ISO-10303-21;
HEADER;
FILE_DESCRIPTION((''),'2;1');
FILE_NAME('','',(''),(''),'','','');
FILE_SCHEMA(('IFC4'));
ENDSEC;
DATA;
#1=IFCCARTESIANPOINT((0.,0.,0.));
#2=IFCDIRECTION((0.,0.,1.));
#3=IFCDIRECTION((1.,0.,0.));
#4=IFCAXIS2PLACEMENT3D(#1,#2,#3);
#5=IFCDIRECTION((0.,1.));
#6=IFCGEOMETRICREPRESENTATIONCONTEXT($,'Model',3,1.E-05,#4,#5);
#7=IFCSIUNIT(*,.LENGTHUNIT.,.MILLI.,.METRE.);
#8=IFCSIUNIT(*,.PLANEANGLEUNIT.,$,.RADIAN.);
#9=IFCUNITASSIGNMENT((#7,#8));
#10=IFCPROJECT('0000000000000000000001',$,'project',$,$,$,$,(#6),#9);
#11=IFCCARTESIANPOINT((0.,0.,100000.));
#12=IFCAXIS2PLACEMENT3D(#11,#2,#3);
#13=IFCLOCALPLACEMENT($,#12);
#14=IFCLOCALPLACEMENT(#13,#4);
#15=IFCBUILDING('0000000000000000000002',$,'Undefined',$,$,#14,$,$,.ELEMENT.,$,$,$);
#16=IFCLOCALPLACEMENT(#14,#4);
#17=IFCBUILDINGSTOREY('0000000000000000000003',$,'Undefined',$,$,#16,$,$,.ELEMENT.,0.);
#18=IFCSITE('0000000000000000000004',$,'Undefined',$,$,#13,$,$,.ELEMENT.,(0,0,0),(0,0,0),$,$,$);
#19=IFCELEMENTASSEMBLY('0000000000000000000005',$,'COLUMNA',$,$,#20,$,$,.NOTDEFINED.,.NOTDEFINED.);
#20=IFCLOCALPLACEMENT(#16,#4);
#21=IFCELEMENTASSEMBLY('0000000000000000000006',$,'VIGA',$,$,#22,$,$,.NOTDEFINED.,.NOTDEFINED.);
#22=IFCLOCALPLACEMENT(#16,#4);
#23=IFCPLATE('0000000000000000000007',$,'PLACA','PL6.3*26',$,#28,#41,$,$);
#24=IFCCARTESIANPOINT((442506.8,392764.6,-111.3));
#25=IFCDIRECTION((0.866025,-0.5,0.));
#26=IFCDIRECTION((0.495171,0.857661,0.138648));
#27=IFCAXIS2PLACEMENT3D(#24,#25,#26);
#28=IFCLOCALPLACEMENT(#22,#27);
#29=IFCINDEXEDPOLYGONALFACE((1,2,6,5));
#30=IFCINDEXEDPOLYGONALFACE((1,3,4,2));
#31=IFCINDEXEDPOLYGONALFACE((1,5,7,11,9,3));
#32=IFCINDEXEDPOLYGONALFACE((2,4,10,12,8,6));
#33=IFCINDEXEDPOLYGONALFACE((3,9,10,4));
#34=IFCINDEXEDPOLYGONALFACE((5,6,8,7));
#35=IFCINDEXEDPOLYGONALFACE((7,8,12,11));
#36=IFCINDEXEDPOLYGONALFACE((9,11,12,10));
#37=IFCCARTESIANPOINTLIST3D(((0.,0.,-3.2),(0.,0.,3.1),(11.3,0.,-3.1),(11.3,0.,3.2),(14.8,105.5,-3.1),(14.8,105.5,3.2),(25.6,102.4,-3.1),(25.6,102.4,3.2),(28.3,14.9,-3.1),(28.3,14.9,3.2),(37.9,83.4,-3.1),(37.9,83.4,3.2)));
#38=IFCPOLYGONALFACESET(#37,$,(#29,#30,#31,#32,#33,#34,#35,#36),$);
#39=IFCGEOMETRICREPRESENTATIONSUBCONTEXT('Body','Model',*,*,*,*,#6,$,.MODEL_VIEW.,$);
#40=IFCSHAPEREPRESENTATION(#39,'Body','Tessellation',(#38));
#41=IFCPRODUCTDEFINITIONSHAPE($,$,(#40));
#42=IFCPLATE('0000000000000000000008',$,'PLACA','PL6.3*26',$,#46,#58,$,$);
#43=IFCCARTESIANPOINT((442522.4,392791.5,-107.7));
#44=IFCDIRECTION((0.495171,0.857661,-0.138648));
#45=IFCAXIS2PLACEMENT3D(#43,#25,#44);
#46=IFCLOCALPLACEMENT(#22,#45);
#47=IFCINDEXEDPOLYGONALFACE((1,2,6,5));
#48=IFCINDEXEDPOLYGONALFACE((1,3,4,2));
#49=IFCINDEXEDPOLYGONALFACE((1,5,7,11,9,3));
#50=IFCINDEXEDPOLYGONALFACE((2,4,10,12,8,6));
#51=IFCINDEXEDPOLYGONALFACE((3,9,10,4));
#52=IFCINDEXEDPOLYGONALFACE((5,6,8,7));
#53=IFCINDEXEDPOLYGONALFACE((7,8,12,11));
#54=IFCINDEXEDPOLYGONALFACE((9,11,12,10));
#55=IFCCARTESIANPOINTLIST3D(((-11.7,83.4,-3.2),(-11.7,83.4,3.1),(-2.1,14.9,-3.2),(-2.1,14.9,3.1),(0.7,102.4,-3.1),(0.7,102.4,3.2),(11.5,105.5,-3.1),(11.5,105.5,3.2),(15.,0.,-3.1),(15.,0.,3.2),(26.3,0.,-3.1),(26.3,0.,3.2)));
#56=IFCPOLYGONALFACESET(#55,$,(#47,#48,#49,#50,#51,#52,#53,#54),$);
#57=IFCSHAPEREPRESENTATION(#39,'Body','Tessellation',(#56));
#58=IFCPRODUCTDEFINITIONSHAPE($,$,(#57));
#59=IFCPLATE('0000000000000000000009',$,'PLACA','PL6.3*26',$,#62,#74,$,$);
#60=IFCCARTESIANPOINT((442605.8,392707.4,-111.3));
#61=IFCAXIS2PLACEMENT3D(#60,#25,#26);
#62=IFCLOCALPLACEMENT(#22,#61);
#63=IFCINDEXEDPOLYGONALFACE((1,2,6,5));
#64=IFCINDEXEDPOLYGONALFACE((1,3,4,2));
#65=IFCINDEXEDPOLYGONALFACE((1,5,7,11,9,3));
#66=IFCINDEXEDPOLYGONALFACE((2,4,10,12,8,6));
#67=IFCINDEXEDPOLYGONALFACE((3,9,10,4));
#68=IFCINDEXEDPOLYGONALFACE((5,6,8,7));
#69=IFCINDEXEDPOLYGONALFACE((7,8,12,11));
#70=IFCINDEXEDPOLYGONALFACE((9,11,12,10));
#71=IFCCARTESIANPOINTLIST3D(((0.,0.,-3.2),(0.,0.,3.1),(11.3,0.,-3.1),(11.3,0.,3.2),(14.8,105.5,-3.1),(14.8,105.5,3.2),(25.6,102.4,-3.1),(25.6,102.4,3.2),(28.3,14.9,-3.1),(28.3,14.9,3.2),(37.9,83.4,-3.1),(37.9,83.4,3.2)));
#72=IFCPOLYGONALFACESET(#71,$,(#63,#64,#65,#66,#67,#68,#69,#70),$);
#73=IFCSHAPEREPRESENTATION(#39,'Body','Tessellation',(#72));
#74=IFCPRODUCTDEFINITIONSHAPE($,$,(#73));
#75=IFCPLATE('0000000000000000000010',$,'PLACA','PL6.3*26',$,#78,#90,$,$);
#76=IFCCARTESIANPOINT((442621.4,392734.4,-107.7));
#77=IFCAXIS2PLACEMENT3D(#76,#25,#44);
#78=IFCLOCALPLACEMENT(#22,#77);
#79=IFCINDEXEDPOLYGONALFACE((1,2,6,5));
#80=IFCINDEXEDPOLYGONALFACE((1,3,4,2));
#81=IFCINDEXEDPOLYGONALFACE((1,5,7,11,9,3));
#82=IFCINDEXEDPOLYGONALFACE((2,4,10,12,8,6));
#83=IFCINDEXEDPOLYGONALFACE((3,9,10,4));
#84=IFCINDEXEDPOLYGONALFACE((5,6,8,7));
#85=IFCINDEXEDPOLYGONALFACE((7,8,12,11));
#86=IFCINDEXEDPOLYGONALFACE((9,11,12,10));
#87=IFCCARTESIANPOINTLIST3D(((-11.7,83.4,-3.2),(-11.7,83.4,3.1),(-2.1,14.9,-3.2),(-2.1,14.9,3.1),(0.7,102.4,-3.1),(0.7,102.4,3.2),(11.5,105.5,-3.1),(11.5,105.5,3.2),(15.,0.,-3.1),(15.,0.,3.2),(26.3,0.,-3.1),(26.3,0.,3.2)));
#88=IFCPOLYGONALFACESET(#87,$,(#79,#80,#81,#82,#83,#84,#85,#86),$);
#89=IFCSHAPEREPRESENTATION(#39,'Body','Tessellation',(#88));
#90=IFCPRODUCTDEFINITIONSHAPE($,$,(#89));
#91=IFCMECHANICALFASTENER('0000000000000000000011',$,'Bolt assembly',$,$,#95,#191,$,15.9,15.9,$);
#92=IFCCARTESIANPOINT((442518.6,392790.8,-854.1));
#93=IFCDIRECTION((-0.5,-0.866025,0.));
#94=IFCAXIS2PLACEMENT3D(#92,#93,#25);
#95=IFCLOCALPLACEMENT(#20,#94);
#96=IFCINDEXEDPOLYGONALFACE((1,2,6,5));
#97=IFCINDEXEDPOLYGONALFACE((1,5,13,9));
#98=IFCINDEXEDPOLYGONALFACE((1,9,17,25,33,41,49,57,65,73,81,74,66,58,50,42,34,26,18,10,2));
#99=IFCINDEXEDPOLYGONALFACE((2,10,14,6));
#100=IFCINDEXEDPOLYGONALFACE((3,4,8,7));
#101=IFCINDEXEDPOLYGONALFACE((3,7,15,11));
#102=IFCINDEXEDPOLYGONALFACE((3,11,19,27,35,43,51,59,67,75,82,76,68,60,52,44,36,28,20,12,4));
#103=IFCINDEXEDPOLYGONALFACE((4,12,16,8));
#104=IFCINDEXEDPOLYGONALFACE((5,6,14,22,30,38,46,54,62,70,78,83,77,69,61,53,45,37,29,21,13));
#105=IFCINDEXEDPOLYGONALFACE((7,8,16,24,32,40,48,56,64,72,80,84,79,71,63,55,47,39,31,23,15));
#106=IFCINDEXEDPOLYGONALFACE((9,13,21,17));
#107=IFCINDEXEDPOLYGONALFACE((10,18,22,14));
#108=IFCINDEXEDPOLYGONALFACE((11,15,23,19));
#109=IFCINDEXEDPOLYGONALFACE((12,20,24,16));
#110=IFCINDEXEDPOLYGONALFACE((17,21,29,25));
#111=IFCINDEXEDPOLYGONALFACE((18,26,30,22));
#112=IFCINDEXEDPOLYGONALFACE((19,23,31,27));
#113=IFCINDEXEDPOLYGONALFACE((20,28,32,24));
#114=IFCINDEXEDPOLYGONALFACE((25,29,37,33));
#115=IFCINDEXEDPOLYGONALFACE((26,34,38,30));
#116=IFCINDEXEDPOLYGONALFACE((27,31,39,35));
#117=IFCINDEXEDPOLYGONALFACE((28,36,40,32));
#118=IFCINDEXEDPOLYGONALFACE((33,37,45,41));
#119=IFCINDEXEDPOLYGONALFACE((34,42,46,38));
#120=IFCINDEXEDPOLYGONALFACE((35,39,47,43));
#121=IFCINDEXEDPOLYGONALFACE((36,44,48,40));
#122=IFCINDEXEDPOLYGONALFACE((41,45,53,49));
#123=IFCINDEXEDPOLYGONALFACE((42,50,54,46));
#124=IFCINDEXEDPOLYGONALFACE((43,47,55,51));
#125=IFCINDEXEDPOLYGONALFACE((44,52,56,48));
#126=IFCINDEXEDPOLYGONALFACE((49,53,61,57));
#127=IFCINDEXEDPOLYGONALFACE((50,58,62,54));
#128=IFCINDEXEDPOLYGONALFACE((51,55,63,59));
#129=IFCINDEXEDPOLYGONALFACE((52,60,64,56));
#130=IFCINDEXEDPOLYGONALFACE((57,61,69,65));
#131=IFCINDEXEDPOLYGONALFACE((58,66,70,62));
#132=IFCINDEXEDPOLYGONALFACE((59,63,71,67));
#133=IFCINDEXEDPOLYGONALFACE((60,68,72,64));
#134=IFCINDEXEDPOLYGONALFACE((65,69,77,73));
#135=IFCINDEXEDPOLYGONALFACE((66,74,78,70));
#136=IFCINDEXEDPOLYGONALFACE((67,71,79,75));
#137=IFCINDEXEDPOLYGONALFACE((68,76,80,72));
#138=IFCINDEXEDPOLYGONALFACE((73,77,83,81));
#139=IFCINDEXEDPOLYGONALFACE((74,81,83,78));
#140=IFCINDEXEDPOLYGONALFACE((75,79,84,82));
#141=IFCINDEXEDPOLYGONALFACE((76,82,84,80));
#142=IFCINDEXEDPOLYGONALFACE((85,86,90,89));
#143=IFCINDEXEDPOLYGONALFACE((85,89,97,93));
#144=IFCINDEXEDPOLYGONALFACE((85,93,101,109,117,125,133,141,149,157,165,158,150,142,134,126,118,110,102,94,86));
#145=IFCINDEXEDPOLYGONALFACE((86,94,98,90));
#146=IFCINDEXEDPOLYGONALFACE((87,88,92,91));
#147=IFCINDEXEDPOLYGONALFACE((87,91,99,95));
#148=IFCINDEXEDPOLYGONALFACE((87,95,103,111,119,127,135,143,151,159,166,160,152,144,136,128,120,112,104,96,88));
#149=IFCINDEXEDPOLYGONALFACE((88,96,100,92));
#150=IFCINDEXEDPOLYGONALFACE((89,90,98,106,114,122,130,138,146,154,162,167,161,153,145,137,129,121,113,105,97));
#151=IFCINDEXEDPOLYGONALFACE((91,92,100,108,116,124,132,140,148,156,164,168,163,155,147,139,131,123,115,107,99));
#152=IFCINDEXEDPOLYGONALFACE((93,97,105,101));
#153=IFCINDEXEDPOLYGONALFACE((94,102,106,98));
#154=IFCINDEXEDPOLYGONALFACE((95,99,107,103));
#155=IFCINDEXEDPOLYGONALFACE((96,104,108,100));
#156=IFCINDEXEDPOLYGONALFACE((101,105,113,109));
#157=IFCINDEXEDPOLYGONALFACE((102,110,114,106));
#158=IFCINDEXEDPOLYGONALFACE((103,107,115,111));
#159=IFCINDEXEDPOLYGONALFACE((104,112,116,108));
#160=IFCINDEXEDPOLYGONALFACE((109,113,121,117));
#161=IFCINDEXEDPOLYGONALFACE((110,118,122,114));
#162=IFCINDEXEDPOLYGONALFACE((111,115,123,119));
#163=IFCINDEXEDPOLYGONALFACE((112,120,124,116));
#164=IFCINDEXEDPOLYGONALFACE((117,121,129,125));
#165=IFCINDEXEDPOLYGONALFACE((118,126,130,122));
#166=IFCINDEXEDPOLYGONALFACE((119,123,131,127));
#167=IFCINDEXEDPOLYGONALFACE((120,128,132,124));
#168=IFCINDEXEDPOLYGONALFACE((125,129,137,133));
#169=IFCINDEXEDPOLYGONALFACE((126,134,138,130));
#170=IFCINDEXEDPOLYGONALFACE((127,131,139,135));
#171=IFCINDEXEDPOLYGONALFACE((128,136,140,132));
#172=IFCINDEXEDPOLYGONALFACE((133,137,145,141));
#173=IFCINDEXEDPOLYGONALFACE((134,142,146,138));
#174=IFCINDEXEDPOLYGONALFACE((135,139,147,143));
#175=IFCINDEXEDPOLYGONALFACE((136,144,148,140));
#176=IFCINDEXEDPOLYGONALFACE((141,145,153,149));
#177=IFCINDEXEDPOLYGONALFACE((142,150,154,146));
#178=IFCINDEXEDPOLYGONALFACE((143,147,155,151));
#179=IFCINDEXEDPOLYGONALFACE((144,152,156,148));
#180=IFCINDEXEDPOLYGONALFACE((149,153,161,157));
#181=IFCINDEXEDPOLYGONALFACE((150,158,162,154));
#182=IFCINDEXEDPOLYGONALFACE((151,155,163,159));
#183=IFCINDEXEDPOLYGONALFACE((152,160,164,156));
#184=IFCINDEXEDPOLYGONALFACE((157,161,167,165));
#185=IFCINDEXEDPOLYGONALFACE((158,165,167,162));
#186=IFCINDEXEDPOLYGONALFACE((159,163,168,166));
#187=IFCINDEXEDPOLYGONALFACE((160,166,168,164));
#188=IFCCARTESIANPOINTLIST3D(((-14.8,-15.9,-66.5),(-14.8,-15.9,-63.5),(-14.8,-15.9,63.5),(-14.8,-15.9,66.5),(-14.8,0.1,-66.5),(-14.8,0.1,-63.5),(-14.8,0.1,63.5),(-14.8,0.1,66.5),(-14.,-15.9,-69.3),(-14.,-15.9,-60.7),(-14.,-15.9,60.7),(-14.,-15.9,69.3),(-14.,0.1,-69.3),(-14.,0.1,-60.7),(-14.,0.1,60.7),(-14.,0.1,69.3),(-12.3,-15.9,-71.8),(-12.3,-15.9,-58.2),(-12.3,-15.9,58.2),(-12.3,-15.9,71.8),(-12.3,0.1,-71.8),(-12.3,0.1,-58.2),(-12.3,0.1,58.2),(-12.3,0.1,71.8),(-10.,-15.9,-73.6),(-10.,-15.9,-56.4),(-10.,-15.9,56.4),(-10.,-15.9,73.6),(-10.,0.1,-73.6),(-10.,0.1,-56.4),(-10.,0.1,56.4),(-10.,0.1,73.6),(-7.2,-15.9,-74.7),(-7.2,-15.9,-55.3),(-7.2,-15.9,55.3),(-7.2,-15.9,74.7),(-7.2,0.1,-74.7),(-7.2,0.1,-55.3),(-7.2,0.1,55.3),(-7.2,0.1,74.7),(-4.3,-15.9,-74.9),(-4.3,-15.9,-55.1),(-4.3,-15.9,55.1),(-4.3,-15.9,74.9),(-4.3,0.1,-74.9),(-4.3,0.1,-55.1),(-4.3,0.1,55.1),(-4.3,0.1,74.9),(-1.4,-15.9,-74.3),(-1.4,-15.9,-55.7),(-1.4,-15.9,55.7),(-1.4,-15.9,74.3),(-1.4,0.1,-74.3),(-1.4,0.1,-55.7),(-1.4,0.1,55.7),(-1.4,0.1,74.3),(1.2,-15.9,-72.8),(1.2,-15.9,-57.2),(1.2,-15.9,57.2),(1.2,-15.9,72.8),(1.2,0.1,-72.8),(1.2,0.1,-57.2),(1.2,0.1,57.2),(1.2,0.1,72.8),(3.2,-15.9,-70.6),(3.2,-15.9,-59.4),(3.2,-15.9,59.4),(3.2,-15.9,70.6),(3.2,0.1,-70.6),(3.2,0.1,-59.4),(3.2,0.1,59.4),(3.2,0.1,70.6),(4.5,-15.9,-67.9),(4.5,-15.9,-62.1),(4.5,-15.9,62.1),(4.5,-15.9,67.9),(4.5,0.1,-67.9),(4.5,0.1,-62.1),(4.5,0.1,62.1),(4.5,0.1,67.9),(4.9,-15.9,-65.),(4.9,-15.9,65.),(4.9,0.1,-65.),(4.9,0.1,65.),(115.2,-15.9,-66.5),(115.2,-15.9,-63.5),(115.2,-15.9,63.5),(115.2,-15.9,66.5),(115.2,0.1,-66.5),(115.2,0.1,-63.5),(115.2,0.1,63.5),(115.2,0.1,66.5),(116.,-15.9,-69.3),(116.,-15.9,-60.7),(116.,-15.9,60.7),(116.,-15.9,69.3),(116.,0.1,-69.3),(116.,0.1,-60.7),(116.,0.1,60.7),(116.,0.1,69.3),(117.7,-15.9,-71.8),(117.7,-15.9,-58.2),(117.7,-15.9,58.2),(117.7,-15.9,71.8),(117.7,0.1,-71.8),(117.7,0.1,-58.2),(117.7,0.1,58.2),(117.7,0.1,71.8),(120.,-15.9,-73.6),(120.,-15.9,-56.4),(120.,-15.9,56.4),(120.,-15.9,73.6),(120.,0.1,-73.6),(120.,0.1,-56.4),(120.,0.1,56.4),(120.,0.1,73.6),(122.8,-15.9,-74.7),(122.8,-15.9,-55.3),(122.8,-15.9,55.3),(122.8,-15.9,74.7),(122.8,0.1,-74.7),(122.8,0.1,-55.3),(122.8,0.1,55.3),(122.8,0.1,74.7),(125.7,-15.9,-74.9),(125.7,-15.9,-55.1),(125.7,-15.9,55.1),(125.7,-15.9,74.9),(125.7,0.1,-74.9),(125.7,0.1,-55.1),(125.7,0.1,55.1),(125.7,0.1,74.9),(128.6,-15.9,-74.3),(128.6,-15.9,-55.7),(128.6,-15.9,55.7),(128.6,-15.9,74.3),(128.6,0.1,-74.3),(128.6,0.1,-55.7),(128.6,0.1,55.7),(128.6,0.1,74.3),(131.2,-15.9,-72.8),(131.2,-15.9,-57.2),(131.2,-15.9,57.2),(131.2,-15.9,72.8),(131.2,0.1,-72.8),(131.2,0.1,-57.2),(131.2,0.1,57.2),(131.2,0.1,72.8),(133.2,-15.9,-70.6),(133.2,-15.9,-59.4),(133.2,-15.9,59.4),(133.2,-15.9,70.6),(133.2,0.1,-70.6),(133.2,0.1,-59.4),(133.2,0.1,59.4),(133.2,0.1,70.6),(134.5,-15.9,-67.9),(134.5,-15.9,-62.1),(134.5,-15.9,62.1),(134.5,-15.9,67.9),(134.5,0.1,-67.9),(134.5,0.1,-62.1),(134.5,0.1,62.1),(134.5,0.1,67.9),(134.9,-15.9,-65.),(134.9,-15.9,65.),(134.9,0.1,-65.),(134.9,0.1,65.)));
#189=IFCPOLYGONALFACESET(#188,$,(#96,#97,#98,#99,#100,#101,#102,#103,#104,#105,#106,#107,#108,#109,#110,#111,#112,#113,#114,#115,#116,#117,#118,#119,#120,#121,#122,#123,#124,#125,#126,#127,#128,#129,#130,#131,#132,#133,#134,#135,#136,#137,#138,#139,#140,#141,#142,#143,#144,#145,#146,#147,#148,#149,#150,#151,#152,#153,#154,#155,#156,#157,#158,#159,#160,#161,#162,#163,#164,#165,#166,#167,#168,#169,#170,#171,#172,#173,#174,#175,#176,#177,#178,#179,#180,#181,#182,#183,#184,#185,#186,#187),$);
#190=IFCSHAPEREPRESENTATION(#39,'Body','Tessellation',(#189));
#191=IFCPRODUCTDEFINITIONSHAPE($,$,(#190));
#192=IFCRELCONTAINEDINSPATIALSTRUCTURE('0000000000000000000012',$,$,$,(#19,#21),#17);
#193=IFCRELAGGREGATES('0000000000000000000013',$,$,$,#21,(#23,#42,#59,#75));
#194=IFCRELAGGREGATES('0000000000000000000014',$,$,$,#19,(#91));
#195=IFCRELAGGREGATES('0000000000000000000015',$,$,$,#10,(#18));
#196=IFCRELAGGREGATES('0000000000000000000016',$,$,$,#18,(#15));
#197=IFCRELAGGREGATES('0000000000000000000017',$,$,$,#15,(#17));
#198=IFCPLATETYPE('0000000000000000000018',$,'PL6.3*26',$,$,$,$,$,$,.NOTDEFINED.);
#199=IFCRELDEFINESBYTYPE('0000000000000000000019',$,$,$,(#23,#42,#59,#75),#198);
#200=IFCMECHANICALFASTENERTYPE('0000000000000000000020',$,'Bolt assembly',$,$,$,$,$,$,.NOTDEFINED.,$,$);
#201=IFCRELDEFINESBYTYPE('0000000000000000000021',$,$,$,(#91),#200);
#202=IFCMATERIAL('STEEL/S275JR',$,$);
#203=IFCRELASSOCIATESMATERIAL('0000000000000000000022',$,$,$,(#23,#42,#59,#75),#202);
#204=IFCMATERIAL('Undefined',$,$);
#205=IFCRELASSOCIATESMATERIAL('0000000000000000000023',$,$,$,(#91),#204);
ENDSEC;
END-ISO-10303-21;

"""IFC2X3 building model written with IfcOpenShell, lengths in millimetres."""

from ifc_helpers import new_model, si_unit, direction, frame, origin_with_axes, origin_2d_with_axis, place, context, subcontext, project, spatial, polyline, circle, outline, extrude, source, transform, mapped, material, type_object, element, aggregate, save


model = new_model("IFC2X3")

# Units and contexts
model_context = context("Model", 3, precision=1e-05, world=origin_with_axes(), true_north=direction((0.0, 1.0)))
body_context = subcontext(model_context, "Body", "Model", "MODEL_VIEW")
ifc_project = project(units=[si_unit("LENGTHUNIT", "METRE", prefix="MILLI"), si_unit("PLANEANGLEUNIT", "RADIAN")], contexts=[model_context])

# Site, building, storey
site_placement = place(None, frame((0.0, 0.0, 100000.0), z_axis=(0.0, 0.0, 1.0), x_axis=(1.0, 0.0, 0.0)))
site = spatial("IfcSite", under=ifc_project, at=site_placement, Name="Undefined", CompositionType="ELEMENT", RefLatitude=(0, 0, 0), RefLongitude=(0, 0, 0))
building_placement = place(site_placement, origin_with_axes())
building = spatial("IfcBuilding", under=site, at=building_placement, Name="Undefined", CompositionType="ELEMENT")
storey_placement = place(building_placement, origin_with_axes())
storey = spatial("IfcBuildingStorey", under=building, at=storey_placement, Name="Undefined", CompositionType="ELEMENT", Elevation=0.0)

# Shared definitions
ifc_material_1 = material(Name="STEEL/S275JR")

# Element assembly
assembly_1_placement = place(storey_placement, origin_with_axes())
assembly_1 = element("IfcElementAssembly", 1, at=assembly_1_placement, inside=storey, Name="COLUMNA", AssemblyPlace="NOTDEFINED", PredefinedType="NOTDEFINED")

# Element assembly
assembly_2_placement = place(storey_placement, origin_with_axes())
assembly_2 = element("IfcElementAssembly", 2, at=assembly_2_placement, inside=storey, Name="VIGA", AssemblyPlace="NOTDEFINED", PredefinedType="NOTDEFINED")

# Plates
plate_type_1 = type_object("IfcPlateType", Name="PL6.3*26", PredefinedType="NOTDEFINED")
plate_1_placement = place(assembly_2_placement, frame((442506.8, 392764.6, -111.3), z_axis=(0.866025, -0.5, 0.0), x_axis=(0.495171, 0.857661, 0.138648)))
plate_1 = element("IfcPlate", 3, at=plate_1_placement, type_object=plate_type_1, material=ifc_material_1, Name="PLACA", Description="PL6.3*26", context=body_context, shape_type="SweptSolid", body=[
    extrude(outline(polyline([(0.0, 0.0), (11.3, 0.0), (28.3, 14.9), (37.9, 83.4), (25.6, 102.4), (14.8, 105.5), (0.0, 0.0)])), frame((0.0, 0.0, -3.1), z_axis=(0.0, 0.0, 1.0), x_axis=(1.0, 0.0, 0.0)), (0.0, 0.0, 1.0), 6.3),
])
plate_2_placement = place(assembly_2_placement, frame((442522.4, 392791.5, -107.7), z_axis=(0.866025, -0.5, 0.0), x_axis=(0.495171, 0.857661, -0.138648)))
plate_2 = element("IfcPlate", 4, at=plate_2_placement, type_object=plate_type_1, material=ifc_material_1, Name="PLACA", Description="PL6.3*26", context=body_context, shape_type="SweptSolid", body=[
    extrude(outline(polyline([(-2.1, 14.9), (15.0, 0.0), (26.3, 0.0), (11.5, 105.5), (0.7, 102.4), (-11.7, 83.4), (-2.1, 14.9)])), frame((0.0, 0.0, -3.1), z_axis=(0.0, 0.0, 1.0), x_axis=(1.0, 0.0, 0.0)), (0.0, 0.0, 1.0), 6.3),
])
plate_3_placement = place(assembly_2_placement, frame((442605.8, 392707.4, -111.3), z_axis=(0.866025, -0.5, 0.0), x_axis=(0.495171, 0.857661, 0.138648)))
plate_3 = element("IfcPlate", 5, at=plate_3_placement, type_object=plate_type_1, material=ifc_material_1, Name="PLACA", Description="PL6.3*26", context=body_context, shape_type="SweptSolid", body=[
    extrude(outline(polyline([(0.0, 0.0), (11.3, 0.0), (28.3, 14.9), (37.9, 83.4), (25.6, 102.4), (14.8, 105.5), (0.0, 0.0)])), frame((0.0, 0.0, -3.1), z_axis=(0.0, 0.0, 1.0), x_axis=(1.0, 0.0, 0.0)), (0.0, 0.0, 1.0), 6.3),
])
plate_4_placement = place(assembly_2_placement, frame((442621.4, 392734.4, -107.7), z_axis=(0.866025, -0.5, 0.0), x_axis=(0.495171, 0.857661, -0.138648)))
plate_4 = element("IfcPlate", 6, at=plate_4_placement, type_object=plate_type_1, material=ifc_material_1, Name="PLACA", Description="PL6.3*26", context=body_context, shape_type="SweptSolid", body=[
    extrude(outline(polyline([(-2.1, 14.9), (15.0, 0.0), (26.3, 0.0), (11.5, 105.5), (0.7, 102.4), (-11.7, 83.4), (-2.1, 14.9)])), frame((0.0, 0.0, -3.1), z_axis=(0.0, 0.0, 1.0), x_axis=(1.0, 0.0, 0.0)), (0.0, 0.0, 1.0), 6.3),
])
aggregate(assembly_2, [plate_1, plate_2, plate_3, plate_4])

# Mechanical fastener
ifc_material_2 = material(Name="Undefined")
mechanical_fastener_type = type_object("IfcMechanicalFastenerType", Name="Bolt assembly")
shared_shape_1 = source(origin_with_axes(), body_context, "Body", "SweptSolid", [
    extrude(circle(Radius=9.9, at=origin_2d_with_axis()), frame((0.0, -15.9, 0.0), z_axis=(0.0, 1.0, 0.0), x_axis=(1.0, 0.0, 0.0)), (0.0, 0.0, 1.0), 16.0),
])
mechanical_fastener_placement = place(assembly_1_placement, frame((442518.6, 392790.8, -854.1), z_axis=(-0.5, -0.866025, 0.0), x_axis=(0.866025, -0.5, 0.0)))
mechanical_fastener = element("IfcMechanicalFastener", 7, at=mechanical_fastener_placement, type_object=mechanical_fastener_type, material=ifc_material_2, Name="Bolt assembly", NominalDiameter=15.9, NominalLength=15.9, context=body_context, shape_type="MappedRepresentation", body=[
    mapped(shared_shape_1, transform((-5.0, 0.0, -65.0))),
    mapped(shared_shape_1, transform((-5.0, 0.0, 65.0))),
    mapped(shared_shape_1, transform((125.0, 0.0, -65.0))),
    mapped(shared_shape_1, transform((125.0, 0.0, 65.0))),
])
aggregate(assembly_1, [mechanical_fastener])

save(model, "model.ifc")
